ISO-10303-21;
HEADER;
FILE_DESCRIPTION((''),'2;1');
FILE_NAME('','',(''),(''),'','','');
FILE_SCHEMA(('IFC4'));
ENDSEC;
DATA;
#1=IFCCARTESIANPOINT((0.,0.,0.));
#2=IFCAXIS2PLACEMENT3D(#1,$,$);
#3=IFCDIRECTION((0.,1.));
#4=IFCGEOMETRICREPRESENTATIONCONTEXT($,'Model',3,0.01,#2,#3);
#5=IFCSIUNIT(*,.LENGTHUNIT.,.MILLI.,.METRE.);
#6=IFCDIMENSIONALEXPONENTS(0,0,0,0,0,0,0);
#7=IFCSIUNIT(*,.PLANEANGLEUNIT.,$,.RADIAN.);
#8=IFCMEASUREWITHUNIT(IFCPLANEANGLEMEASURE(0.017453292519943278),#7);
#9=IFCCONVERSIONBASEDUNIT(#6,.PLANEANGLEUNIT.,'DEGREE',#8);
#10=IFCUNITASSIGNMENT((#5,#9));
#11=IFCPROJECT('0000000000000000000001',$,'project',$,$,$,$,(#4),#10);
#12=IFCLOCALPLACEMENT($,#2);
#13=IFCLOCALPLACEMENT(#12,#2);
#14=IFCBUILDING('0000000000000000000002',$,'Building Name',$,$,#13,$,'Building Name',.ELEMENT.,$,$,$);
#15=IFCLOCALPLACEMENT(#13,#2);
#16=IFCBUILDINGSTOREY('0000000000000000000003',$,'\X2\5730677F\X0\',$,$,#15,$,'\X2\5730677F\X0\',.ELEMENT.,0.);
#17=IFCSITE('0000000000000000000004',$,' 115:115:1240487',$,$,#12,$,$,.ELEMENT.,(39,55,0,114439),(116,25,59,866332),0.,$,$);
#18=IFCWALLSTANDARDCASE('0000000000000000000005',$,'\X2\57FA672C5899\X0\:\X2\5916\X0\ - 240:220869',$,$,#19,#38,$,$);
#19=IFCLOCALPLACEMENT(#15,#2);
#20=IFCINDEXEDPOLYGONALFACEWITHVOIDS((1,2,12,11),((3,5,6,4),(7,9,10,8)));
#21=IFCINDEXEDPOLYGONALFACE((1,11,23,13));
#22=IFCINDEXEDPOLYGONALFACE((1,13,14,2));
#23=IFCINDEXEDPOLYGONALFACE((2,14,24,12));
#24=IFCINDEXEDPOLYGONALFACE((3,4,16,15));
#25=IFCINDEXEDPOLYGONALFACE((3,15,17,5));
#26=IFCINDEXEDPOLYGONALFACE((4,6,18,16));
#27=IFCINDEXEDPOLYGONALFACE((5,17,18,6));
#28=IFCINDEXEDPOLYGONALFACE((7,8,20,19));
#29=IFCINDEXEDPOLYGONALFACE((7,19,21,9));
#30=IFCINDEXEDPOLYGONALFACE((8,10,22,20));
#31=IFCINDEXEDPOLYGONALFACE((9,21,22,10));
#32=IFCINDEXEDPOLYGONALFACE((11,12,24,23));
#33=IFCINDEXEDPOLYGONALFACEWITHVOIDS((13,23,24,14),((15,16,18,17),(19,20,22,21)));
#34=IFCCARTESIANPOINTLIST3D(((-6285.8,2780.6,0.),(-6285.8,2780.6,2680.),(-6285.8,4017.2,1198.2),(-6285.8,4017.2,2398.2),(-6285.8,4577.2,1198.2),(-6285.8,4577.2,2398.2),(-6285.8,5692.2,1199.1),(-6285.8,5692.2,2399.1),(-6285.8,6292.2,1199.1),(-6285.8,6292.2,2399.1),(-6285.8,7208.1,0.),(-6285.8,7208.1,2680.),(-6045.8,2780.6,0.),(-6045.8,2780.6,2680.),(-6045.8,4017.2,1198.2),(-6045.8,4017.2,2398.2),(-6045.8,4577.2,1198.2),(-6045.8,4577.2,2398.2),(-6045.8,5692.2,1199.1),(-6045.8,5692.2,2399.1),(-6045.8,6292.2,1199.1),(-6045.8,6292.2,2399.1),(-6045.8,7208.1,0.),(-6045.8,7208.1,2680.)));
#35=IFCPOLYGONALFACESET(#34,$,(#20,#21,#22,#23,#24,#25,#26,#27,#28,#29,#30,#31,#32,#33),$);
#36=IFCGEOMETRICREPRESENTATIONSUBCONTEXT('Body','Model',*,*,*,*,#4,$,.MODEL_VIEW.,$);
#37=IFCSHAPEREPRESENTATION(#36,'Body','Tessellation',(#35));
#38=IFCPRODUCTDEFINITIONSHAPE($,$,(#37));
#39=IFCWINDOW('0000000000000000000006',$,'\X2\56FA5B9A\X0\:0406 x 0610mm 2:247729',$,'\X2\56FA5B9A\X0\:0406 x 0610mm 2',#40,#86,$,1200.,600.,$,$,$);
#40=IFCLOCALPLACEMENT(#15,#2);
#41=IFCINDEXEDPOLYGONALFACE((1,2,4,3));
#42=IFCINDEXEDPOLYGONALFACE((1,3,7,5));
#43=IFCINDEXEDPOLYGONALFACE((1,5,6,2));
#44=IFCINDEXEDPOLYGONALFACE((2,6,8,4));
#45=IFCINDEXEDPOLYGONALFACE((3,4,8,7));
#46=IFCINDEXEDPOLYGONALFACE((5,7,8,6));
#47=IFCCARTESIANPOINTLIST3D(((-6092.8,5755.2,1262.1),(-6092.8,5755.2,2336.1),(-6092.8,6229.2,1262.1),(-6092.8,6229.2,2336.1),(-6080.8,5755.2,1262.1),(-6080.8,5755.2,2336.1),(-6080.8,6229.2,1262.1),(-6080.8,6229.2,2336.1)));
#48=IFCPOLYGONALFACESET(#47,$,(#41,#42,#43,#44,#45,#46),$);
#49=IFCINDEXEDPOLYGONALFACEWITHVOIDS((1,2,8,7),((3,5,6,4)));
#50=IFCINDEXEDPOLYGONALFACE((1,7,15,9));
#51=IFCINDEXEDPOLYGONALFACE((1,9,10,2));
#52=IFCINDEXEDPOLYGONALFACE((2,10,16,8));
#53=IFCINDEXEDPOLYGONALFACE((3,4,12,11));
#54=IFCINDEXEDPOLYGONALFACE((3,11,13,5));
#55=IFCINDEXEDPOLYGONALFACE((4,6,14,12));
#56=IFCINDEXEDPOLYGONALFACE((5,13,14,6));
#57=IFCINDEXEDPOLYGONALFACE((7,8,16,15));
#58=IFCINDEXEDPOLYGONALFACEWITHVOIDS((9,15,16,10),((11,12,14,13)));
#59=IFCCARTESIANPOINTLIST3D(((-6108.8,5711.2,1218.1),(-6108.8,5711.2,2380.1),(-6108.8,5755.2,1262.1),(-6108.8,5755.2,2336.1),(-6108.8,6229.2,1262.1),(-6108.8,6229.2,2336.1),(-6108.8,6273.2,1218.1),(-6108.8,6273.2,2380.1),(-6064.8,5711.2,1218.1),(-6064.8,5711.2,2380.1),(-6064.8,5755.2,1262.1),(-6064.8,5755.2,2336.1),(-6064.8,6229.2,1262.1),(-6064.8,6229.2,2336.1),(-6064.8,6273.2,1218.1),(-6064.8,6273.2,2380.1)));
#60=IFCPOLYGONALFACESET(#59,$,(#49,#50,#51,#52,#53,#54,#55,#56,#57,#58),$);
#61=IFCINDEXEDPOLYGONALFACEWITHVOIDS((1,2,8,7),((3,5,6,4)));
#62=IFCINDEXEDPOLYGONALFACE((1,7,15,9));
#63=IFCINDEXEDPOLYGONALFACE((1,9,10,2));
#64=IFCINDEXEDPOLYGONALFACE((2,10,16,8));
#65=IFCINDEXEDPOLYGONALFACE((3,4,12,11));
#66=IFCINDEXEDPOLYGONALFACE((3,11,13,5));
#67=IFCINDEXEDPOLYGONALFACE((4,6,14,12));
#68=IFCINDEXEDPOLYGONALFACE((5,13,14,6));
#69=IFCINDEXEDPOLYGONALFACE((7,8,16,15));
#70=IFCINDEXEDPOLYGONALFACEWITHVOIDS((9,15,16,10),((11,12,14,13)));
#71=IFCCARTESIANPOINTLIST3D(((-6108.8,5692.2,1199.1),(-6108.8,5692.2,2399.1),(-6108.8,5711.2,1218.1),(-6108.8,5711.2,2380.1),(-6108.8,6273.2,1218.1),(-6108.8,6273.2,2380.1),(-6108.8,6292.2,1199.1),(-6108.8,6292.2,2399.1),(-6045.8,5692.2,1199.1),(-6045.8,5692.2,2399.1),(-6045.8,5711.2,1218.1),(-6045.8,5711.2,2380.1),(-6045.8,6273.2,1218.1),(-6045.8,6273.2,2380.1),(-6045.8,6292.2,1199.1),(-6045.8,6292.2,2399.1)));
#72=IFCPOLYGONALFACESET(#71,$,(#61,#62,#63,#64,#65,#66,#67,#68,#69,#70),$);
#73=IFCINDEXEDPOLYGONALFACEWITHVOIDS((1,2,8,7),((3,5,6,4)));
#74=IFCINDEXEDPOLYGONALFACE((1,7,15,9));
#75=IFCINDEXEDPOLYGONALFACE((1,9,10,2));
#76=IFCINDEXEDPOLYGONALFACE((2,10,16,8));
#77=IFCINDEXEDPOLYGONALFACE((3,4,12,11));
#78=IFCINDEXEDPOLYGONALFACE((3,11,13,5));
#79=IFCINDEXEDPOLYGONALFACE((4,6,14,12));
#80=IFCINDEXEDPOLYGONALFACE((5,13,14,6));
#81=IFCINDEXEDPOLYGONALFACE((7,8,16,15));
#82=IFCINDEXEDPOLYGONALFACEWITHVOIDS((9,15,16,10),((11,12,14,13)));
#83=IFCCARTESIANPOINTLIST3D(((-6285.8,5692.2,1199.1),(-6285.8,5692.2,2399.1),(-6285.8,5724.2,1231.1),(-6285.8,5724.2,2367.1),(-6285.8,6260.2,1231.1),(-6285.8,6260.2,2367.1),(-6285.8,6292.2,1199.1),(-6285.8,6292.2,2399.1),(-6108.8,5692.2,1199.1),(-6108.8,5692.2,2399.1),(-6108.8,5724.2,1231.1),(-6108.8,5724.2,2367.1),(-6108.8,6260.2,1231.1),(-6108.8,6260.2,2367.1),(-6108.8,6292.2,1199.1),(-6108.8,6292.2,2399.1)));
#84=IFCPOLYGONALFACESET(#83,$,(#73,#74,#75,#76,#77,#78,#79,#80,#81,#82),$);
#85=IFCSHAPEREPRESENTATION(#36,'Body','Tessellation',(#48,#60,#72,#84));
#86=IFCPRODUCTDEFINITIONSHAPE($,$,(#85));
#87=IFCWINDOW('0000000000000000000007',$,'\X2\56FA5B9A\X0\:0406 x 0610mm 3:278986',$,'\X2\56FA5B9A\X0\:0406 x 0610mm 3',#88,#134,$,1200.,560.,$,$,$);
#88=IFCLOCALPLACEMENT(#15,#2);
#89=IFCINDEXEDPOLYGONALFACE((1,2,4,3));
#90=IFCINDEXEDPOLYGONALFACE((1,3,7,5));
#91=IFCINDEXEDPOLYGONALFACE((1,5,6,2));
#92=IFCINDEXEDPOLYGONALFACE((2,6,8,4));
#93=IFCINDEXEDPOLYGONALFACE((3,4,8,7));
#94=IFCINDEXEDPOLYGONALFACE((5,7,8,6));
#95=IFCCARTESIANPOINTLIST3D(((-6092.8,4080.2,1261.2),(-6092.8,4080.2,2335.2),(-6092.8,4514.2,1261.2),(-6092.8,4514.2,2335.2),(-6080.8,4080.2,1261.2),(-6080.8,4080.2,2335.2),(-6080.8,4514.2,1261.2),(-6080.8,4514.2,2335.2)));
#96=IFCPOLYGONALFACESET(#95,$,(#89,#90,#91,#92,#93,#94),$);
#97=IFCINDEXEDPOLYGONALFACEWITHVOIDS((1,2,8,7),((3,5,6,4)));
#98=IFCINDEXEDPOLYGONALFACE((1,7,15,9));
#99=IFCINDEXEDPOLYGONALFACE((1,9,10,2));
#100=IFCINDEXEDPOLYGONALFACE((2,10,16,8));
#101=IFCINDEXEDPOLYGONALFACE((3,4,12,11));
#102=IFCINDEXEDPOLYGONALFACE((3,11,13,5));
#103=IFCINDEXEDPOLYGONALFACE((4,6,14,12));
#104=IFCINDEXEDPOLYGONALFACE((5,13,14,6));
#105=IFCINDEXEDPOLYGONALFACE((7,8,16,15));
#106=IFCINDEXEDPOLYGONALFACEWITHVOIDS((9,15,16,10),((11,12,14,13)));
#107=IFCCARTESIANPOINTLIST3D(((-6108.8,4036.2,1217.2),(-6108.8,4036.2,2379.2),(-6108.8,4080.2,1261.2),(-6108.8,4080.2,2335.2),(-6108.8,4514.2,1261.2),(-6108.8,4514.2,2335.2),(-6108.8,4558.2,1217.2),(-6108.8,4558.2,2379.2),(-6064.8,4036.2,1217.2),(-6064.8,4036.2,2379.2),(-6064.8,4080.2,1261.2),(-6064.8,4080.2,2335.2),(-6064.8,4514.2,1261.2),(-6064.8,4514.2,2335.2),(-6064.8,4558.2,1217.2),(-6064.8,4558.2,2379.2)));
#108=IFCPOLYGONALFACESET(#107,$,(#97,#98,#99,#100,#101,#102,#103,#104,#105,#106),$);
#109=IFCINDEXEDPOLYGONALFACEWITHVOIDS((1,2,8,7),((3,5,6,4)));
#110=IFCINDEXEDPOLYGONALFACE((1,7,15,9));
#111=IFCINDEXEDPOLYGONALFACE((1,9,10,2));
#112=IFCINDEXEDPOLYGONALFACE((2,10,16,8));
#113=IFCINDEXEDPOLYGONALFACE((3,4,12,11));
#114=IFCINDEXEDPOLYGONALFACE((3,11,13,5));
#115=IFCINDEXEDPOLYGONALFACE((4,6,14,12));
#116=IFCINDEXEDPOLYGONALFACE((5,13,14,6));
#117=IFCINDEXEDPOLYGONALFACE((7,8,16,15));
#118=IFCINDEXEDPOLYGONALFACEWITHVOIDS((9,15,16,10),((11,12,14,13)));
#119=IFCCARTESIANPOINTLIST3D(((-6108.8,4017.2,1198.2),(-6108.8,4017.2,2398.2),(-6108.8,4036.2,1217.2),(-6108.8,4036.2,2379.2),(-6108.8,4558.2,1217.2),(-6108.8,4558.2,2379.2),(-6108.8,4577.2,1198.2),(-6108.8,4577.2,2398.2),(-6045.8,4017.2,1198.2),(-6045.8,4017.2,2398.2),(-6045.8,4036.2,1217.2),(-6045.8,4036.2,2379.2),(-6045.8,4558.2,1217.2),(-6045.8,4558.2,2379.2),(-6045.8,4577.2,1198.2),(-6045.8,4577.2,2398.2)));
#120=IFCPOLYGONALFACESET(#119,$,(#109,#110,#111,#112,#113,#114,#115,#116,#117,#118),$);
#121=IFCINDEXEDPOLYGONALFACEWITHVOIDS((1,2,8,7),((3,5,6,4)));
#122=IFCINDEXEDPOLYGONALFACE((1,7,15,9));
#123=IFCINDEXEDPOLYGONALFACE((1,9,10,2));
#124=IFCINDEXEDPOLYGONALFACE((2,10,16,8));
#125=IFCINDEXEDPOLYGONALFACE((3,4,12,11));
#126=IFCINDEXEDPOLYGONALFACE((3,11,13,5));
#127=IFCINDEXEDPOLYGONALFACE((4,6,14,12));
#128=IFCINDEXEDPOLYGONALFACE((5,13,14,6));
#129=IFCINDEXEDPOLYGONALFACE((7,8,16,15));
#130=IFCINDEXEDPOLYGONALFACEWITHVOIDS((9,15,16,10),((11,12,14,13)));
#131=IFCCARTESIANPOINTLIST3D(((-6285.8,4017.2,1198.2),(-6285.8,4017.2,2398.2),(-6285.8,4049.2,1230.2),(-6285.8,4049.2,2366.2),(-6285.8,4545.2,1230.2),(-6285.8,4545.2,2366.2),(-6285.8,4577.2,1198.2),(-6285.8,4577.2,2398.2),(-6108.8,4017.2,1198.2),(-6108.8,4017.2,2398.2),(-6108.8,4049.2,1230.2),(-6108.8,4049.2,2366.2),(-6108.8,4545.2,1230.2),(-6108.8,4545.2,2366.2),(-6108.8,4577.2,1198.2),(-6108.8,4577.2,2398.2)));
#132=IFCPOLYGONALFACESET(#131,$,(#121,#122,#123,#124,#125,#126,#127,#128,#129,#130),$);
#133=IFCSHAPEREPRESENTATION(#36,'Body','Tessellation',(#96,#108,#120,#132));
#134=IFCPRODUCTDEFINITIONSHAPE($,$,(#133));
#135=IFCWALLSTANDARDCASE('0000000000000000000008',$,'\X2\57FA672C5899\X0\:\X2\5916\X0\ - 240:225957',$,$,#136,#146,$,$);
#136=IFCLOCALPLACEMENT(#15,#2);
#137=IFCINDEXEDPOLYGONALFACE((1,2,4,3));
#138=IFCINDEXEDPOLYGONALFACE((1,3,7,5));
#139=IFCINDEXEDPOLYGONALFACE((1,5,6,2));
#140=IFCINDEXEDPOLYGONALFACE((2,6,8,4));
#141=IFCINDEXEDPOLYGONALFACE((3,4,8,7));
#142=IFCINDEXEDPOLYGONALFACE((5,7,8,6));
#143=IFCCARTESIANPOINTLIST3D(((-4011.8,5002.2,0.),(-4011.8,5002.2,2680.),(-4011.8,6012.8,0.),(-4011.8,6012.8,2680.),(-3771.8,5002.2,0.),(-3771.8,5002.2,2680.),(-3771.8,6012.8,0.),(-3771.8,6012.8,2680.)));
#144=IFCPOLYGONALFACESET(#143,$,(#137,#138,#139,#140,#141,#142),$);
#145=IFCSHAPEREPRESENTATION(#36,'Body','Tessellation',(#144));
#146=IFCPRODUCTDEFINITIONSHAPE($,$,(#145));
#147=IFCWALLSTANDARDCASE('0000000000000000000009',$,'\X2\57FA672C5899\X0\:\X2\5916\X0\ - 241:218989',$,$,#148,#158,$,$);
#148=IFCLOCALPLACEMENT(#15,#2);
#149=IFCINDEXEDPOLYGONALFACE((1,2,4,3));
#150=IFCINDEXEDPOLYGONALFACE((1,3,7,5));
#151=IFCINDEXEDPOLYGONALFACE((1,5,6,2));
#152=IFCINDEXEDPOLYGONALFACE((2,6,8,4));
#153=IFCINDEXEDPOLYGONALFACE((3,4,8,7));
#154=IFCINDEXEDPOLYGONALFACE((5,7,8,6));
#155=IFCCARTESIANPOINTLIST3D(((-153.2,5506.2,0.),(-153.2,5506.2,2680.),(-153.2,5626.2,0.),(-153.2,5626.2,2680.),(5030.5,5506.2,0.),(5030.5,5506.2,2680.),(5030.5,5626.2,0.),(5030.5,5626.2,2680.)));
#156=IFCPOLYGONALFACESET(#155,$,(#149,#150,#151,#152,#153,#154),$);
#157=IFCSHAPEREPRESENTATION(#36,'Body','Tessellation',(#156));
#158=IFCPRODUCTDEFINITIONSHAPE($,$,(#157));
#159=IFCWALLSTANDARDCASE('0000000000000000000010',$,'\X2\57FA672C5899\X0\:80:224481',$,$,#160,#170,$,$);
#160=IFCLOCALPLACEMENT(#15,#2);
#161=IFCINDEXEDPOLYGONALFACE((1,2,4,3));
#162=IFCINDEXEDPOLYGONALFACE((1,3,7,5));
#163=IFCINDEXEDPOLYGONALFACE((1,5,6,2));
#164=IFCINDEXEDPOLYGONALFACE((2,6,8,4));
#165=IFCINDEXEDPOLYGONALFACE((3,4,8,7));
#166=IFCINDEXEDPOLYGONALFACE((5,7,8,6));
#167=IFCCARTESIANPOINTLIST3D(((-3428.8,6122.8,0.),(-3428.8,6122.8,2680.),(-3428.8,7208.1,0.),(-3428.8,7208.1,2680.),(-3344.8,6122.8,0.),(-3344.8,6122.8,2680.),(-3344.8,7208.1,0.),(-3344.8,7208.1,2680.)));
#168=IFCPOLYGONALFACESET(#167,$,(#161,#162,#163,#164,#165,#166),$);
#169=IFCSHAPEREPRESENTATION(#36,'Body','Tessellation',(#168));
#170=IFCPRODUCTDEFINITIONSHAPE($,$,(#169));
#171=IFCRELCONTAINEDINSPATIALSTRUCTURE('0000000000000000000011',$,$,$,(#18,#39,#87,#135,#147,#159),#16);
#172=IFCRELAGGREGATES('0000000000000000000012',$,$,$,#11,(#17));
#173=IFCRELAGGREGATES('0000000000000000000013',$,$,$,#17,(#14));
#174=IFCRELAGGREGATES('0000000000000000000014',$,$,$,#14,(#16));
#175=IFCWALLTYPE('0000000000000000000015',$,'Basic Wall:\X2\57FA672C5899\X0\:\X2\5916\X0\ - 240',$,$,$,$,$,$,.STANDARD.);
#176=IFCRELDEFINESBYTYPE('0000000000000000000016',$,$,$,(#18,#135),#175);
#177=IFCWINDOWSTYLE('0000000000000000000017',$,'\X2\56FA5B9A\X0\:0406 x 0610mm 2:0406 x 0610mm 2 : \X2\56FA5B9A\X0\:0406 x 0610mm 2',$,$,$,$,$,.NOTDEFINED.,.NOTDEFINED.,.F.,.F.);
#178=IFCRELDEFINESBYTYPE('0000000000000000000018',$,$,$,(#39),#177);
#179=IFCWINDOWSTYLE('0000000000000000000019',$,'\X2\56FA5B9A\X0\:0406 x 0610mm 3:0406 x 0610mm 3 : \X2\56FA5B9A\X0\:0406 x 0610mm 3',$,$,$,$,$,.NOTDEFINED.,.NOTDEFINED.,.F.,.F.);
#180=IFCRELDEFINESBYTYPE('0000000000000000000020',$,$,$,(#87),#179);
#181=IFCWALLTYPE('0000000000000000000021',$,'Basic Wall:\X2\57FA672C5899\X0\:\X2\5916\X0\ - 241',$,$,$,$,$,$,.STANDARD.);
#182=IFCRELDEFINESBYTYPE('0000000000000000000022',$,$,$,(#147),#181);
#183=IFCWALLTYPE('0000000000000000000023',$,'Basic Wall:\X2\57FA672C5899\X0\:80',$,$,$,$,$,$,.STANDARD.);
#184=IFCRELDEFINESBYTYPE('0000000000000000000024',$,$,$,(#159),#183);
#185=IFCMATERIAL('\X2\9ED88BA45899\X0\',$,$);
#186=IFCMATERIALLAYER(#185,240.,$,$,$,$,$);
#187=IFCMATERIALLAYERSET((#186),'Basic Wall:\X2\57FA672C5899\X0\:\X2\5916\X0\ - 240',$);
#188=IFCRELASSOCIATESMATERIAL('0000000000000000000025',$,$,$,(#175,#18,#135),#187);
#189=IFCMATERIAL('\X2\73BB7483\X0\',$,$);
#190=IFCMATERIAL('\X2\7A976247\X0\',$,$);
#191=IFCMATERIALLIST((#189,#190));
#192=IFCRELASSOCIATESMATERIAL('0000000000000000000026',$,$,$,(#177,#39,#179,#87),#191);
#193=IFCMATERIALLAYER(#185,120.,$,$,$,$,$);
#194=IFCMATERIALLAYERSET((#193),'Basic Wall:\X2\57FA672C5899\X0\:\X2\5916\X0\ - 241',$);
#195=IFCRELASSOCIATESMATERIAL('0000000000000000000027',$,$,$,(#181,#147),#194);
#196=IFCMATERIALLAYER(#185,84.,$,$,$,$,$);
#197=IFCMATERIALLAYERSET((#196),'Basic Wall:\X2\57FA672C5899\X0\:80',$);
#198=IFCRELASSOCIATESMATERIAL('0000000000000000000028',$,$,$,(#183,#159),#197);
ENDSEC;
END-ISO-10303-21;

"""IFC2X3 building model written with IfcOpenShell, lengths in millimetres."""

from ifc_helpers import new_model, entity, si_unit, converted_unit, direction, frame, frame_2d, origin, origin_2d_with_axis, place, context, subcontext, project, spatial, polyline, rectangle, outline, extrude, source, transform, mapped, material, material_list, layer, layer_set, layer_usage, type_object, type_shapes, element, fill, save


model = new_model("IFC2X3")

# Units and contexts
model_context = context("Model", 3, precision=0.01, world=origin(), true_north=direction((0.0, 1.0)))
body_context = subcontext(model_context, "Body", "Model", "MODEL_VIEW")
ifc_project = project(units=[si_unit("LENGTHUNIT", "METRE", prefix="MILLI"), converted_unit("PLANEANGLEUNIT", "DEGREE", entity("IfcPlaneAngleMeasure", 0.017453292519943278), si_unit("PLANEANGLEUNIT", "RADIAN"), dimensions=[0, 0, 0, 0, 0, 0, 0])], contexts=[model_context])

# Site, building, storey
site_placement = place(None, origin())
site = spatial("IfcSite", under=ifc_project, at=site_placement, Name=" 115:115:1240487", CompositionType="ELEMENT", RefLatitude=(39, 55, 0, 114439), RefLongitude=(116, 25, 59, 866332), RefElevation=0.0)
building_placement = place(site_placement, origin())
building = spatial("IfcBuilding", under=site, at=building_placement, Name="Building Name", LongName="Building Name", CompositionType="ELEMENT")
storey_placement = place(building_placement, origin())
storey = spatial("IfcBuildingStorey", under=building, at=storey_placement, Name="地板", LongName="地板", CompositionType="ELEMENT", Elevation=0.0)

# Shared definitions
ifc_material_1 = material(Name="默认墙")
ifc_layer_1 = layer(ifc_material_1, 240.0)
ifc_layer_set_1 = layer_set([ifc_layer_1], Name="Basic Wall:基本墙:外 - 240")
wall_type_1 = type_object("IfcWallType", Name="Basic Wall:基本墙:外 - 240", PredefinedType="STANDARD", material=ifc_layer_set_1)
ifc_material_2 = material(Name="玻璃")
ifc_material_3 = material(Name="窗扇")
ifc_material_list_1 = material_list([ifc_material_2, ifc_material_3])

# Wall, openings, windows
ifc_layer_usage_1 = layer_usage(ifc_layer_set_1, "AXIS2", "NEGATIVE", 120.0)
wall_1_placement = place(storey_placement, frame((-6165.8, 7208.1, 0.0), z_axis=(0.0, 0.0, 1.0), x_axis=(0.0, -1.0, 0.0)))
wall_1 = element("IfcWallStandardCase", 1, at=wall_1_placement, inside=storey, type_object=wall_type_1, material=ifc_layer_usage_1, Name="基本墙:外 - 240:220869", context=body_context, shape_type="SweptSolid", body=[
    extrude(rectangle(XDim=4427.5, YDim=240.0, at=frame_2d((2213.7, 0.0), x_axis=(-1.0, 0.0))), origin(), (0.0, 0.0, 1.0), 2680.0),
])
opening_1_placement = place(wall_1_placement, frame((7208.1, 6165.8, 0.0), z_axis=(0.0, 0.0, 1.0), x_axis=(0.0, 1.0, 0.0)))
opening_1 = element("IfcOpeningElement", 2, at=opening_1_placement, cuts=wall_1, ObjectType="Opening", context=body_context, shape_type="SweptSolid", body=[
    extrude(rectangle(XDim=1200.0, YDim=600.0, at=frame_2d((0.0, 0.0), x_axis=(0.0, 1.0))), frame((-6288.2, 5992.2, 1799.1), z_axis=(1.0, 0.0, 0.0), x_axis=(0.0, -1.0, 0.0)), (0.0, 0.0, 1.0), 244.8),
])
opening_2_placement = place(wall_1_placement, frame((7208.1, 6165.8, 0.0), z_axis=(0.0, 0.0, 1.0), x_axis=(0.0, 1.0, 0.0)))
opening_2 = element("IfcOpeningElement", 3, at=opening_2_placement, cuts=wall_1, ObjectType="Opening", context=body_context, shape_type="SweptSolid", body=[
    extrude(rectangle(XDim=1200.0, YDim=560.0, at=frame_2d((0.0, 0.0), x_axis=(0.0, 1.0))), frame((-6288.2, 4297.2, 1798.2), z_axis=(1.0, 0.0, 0.0), x_axis=(0.0, -1.0, 0.0)), (0.0, 0.0, 1.0), 244.8),
])
window_style_1 = type_object("IfcWindowStyle", Name="固定:0406 x 0610mm 2:0406 x 0610mm 2 : 固定:0406 x 0610mm 2", ConstructionType="NOTDEFINED", OperationType="NOTDEFINED", ParameterTakesPrecedence=False, Sizeable=False, material=ifc_material_list_1)
shared_shape_1 = source(origin(), body_context, "Body", "SweptSolid", [
    extrude(rectangle(XDim=474.0, YDim=12.0, at=origin_2d_with_axis()), frame((300.0, -43.4, 63.0)), (0.0, 0.0, 1.0), 1074.0),
    extrude(outline(polyline([(-581.0, -281.0), (581.0, -281.0), (581.0, 281.0), (-581.0, 281.0), (-581.0, -281.0)]), holes=[polyline([(537.0, 237.0), (537.0, -237.0), (-537.0, -237.0), (-537.0, 237.0), (537.0, 237.0)])]), frame((300.0, -65.4, 600.0), z_axis=(0.0, 1.0, 0.0), x_axis=(0.0, 0.0, -1.0)), (0.0, 0.0, 1.0), 44.0),
    extrude(outline(polyline([(-600.0, -300.0), (600.0, -300.0), (600.0, 300.0), (-600.0, 300.0), (-600.0, -300.0)]), holes=[polyline([(581.0, 281.0), (581.0, -281.0), (-581.0, -281.0), (-581.0, 281.0), (581.0, 281.0)])]), frame((300.0, -65.4, 600.0), z_axis=(0.0, 1.0, 0.0), x_axis=(0.0, 0.0, -1.0)), (0.0, 0.0, 1.0), 63.0),
    extrude(outline(polyline([(-600.0, -300.0), (600.0, -300.0), (600.0, 300.0), (-600.0, 300.0), (-600.0, -300.0)]), holes=[polyline([(568.0, 268.0), (568.0, -268.0), (-568.0, -268.0), (-568.0, 268.0), (568.0, 268.0)])]), frame((300.0, -242.4, 600.0), z_axis=(0.0, 1.0, 0.0), x_axis=(0.0, 0.0, -1.0)), (0.0, 0.0, 1.0), 177.0),
])
type_shapes(window_style_1, [shared_shape_1])
window_1_placement = place(opening_1_placement, frame((-6043.4, 6292.2, 1199.1), z_axis=(0.0, 0.0, 1.0), x_axis=(0.0, -1.0, 0.0)))
window_1 = element("IfcWindow", 4, at=window_1_placement, inside=storey, type_object=window_style_1, material=ifc_material_list_1, Name="固定:0406 x 0610mm 2:247729", ObjectType="固定:0406 x 0610mm 2", OverallHeight=1200.0, OverallWidth=600.0, context=body_context, shape_type="MappedRepresentation", body=[
    mapped(shared_shape_1, transform((0.0, 0.0, 0.0), scale=1.0)),
])
fill(opening_1, window_1)
window_style_2 = type_object("IfcWindowStyle", Name="固定:0406 x 0610mm 3:0406 x 0610mm 3 : 固定:0406 x 0610mm 3", ConstructionType="NOTDEFINED", OperationType="NOTDEFINED", ParameterTakesPrecedence=False, Sizeable=False, material=ifc_material_list_1)
shared_shape_2 = source(origin(), body_context, "Body", "SweptSolid", [
    extrude(rectangle(XDim=434.0, YDim=12.0, at=origin_2d_with_axis()), frame((280.0, -43.4, 63.0)), (0.0, 0.0, 1.0), 1074.0),
    extrude(outline(polyline([(-581.0, -261.0), (581.0, -261.0), (581.0, 261.0), (-581.0, 261.0), (-581.0, -261.0)]), holes=[polyline([(537.0, 217.0), (537.0, -217.0), (-537.0, -217.0), (-537.0, 217.0), (537.0, 217.0)])]), frame((280.0, -65.4, 600.0), z_axis=(0.0, 1.0, 0.0), x_axis=(0.0, 0.0, -1.0)), (0.0, 0.0, 1.0), 44.0),
    extrude(outline(polyline([(-600.0, -280.0), (600.0, -280.0), (600.0, 280.0), (-600.0, 280.0), (-600.0, -280.0)]), holes=[polyline([(581.0, 261.0), (581.0, -261.0), (-581.0, -261.0), (-581.0, 261.0), (581.0, 261.0)])]), frame((280.0, -65.4, 600.0), z_axis=(0.0, 1.0, 0.0), x_axis=(0.0, 0.0, -1.0)), (0.0, 0.0, 1.0), 63.0),
    extrude(outline(polyline([(-600.0, -280.0), (600.0, -280.0), (600.0, 280.0), (-600.0, 280.0), (-600.0, -280.0)]), holes=[polyline([(568.0, 248.0), (568.0, -248.0), (-568.0, -248.0), (-568.0, 248.0), (568.0, 248.0)])]), frame((280.0, -242.4, 600.0), z_axis=(0.0, 1.0, 0.0), x_axis=(0.0, 0.0, -1.0)), (0.0, 0.0, 1.0), 177.0),
])
type_shapes(window_style_2, [shared_shape_2])
window_2_placement = place(opening_2_placement, frame((-6043.4, 4577.2, 1198.2), z_axis=(0.0, 0.0, 1.0), x_axis=(0.0, -1.0, 0.0)))
window_2 = element("IfcWindow", 5, at=window_2_placement, inside=storey, type_object=window_style_2, material=ifc_material_list_1, Name="固定:0406 x 0610mm 3:278986", ObjectType="固定:0406 x 0610mm 3", OverallHeight=1200.0, OverallWidth=560.0, context=body_context, shape_type="MappedRepresentation", body=[
    mapped(shared_shape_2, transform((0.0, 0.0, 0.0), scale=1.0)),
])
fill(opening_2, window_2)

# Walls
ifc_layer_usage_2 = layer_usage(ifc_layer_set_1, "AXIS2", "NEGATIVE", 120.0)
wall_2_placement = place(storey_placement, frame((-3891.8, 6012.8, 0.0), z_axis=(0.0, 0.0, 1.0), x_axis=(0.0, -1.0, 0.0)))
element("IfcWallStandardCase", 6, at=wall_2_placement, inside=storey, type_object=wall_type_1, material=ifc_layer_usage_2, Name="基本墙:外 - 240:225957", context=body_context, shape_type="SweptSolid", body=[
    extrude(rectangle(XDim=1010.6, YDim=240.0, at=frame_2d((505.3, 0.0), x_axis=(-1.0, 0.0))), origin(), (0.0, 0.0, 1.0), 2680.0),
])
ifc_layer_2 = layer(ifc_material_1, 120.0)
ifc_layer_set_2 = layer_set([ifc_layer_2], Name="Basic Wall:基本墙:外 - 241")
ifc_layer_usage_3 = layer_usage(ifc_layer_set_2, "AXIS2", "NEGATIVE", 60.0)
wall_type_2 = type_object("IfcWallType", Name="Basic Wall:基本墙:外 - 241", PredefinedType="STANDARD", material=ifc_layer_set_2)
wall_3_placement = place(storey_placement, frame((5030.5, 5566.2, 0.0), z_axis=(0.0, 0.0, 1.0), x_axis=(-1.0, 0.0, 0.0)))
element("IfcWallStandardCase", 7, at=wall_3_placement, inside=storey, type_object=wall_type_2, material=ifc_layer_usage_3, Name="基本墙:外 - 241:218989", context=body_context, shape_type="SweptSolid", body=[
    extrude(rectangle(XDim=5183.7, YDim=120.0, at=frame_2d((2591.8, 0.0), x_axis=(-1.0, 0.0))), origin(), (0.0, 0.0, 1.0), 2680.0),
])
ifc_layer_3 = layer(ifc_material_1, 84.0)
ifc_layer_set_3 = layer_set([ifc_layer_3], Name="Basic Wall:基本墙:80")
ifc_layer_usage_4 = layer_usage(ifc_layer_set_3, "AXIS2", "NEGATIVE", 42.0)
wall_type_3 = type_object("IfcWallType", Name="Basic Wall:基本墙:80", PredefinedType="STANDARD", material=ifc_layer_set_3)
wall_4_placement = place(storey_placement, frame((-3386.8, 7208.1, 0.0), z_axis=(0.0, 0.0, 1.0), x_axis=(0.0, -1.0, 0.0)))
element("IfcWallStandardCase", 8, at=wall_4_placement, inside=storey, type_object=wall_type_3, material=ifc_layer_usage_4, Name="基本墙:80:224481", context=body_context, shape_type="SweptSolid", body=[
    extrude(rectangle(XDim=1085.3, YDim=84.0, at=frame_2d((542.6, 0.0), x_axis=(-1.0, 0.0))), origin(), (0.0, 0.0, 1.0), 2680.0),
])

save(model, "model.ifc")
